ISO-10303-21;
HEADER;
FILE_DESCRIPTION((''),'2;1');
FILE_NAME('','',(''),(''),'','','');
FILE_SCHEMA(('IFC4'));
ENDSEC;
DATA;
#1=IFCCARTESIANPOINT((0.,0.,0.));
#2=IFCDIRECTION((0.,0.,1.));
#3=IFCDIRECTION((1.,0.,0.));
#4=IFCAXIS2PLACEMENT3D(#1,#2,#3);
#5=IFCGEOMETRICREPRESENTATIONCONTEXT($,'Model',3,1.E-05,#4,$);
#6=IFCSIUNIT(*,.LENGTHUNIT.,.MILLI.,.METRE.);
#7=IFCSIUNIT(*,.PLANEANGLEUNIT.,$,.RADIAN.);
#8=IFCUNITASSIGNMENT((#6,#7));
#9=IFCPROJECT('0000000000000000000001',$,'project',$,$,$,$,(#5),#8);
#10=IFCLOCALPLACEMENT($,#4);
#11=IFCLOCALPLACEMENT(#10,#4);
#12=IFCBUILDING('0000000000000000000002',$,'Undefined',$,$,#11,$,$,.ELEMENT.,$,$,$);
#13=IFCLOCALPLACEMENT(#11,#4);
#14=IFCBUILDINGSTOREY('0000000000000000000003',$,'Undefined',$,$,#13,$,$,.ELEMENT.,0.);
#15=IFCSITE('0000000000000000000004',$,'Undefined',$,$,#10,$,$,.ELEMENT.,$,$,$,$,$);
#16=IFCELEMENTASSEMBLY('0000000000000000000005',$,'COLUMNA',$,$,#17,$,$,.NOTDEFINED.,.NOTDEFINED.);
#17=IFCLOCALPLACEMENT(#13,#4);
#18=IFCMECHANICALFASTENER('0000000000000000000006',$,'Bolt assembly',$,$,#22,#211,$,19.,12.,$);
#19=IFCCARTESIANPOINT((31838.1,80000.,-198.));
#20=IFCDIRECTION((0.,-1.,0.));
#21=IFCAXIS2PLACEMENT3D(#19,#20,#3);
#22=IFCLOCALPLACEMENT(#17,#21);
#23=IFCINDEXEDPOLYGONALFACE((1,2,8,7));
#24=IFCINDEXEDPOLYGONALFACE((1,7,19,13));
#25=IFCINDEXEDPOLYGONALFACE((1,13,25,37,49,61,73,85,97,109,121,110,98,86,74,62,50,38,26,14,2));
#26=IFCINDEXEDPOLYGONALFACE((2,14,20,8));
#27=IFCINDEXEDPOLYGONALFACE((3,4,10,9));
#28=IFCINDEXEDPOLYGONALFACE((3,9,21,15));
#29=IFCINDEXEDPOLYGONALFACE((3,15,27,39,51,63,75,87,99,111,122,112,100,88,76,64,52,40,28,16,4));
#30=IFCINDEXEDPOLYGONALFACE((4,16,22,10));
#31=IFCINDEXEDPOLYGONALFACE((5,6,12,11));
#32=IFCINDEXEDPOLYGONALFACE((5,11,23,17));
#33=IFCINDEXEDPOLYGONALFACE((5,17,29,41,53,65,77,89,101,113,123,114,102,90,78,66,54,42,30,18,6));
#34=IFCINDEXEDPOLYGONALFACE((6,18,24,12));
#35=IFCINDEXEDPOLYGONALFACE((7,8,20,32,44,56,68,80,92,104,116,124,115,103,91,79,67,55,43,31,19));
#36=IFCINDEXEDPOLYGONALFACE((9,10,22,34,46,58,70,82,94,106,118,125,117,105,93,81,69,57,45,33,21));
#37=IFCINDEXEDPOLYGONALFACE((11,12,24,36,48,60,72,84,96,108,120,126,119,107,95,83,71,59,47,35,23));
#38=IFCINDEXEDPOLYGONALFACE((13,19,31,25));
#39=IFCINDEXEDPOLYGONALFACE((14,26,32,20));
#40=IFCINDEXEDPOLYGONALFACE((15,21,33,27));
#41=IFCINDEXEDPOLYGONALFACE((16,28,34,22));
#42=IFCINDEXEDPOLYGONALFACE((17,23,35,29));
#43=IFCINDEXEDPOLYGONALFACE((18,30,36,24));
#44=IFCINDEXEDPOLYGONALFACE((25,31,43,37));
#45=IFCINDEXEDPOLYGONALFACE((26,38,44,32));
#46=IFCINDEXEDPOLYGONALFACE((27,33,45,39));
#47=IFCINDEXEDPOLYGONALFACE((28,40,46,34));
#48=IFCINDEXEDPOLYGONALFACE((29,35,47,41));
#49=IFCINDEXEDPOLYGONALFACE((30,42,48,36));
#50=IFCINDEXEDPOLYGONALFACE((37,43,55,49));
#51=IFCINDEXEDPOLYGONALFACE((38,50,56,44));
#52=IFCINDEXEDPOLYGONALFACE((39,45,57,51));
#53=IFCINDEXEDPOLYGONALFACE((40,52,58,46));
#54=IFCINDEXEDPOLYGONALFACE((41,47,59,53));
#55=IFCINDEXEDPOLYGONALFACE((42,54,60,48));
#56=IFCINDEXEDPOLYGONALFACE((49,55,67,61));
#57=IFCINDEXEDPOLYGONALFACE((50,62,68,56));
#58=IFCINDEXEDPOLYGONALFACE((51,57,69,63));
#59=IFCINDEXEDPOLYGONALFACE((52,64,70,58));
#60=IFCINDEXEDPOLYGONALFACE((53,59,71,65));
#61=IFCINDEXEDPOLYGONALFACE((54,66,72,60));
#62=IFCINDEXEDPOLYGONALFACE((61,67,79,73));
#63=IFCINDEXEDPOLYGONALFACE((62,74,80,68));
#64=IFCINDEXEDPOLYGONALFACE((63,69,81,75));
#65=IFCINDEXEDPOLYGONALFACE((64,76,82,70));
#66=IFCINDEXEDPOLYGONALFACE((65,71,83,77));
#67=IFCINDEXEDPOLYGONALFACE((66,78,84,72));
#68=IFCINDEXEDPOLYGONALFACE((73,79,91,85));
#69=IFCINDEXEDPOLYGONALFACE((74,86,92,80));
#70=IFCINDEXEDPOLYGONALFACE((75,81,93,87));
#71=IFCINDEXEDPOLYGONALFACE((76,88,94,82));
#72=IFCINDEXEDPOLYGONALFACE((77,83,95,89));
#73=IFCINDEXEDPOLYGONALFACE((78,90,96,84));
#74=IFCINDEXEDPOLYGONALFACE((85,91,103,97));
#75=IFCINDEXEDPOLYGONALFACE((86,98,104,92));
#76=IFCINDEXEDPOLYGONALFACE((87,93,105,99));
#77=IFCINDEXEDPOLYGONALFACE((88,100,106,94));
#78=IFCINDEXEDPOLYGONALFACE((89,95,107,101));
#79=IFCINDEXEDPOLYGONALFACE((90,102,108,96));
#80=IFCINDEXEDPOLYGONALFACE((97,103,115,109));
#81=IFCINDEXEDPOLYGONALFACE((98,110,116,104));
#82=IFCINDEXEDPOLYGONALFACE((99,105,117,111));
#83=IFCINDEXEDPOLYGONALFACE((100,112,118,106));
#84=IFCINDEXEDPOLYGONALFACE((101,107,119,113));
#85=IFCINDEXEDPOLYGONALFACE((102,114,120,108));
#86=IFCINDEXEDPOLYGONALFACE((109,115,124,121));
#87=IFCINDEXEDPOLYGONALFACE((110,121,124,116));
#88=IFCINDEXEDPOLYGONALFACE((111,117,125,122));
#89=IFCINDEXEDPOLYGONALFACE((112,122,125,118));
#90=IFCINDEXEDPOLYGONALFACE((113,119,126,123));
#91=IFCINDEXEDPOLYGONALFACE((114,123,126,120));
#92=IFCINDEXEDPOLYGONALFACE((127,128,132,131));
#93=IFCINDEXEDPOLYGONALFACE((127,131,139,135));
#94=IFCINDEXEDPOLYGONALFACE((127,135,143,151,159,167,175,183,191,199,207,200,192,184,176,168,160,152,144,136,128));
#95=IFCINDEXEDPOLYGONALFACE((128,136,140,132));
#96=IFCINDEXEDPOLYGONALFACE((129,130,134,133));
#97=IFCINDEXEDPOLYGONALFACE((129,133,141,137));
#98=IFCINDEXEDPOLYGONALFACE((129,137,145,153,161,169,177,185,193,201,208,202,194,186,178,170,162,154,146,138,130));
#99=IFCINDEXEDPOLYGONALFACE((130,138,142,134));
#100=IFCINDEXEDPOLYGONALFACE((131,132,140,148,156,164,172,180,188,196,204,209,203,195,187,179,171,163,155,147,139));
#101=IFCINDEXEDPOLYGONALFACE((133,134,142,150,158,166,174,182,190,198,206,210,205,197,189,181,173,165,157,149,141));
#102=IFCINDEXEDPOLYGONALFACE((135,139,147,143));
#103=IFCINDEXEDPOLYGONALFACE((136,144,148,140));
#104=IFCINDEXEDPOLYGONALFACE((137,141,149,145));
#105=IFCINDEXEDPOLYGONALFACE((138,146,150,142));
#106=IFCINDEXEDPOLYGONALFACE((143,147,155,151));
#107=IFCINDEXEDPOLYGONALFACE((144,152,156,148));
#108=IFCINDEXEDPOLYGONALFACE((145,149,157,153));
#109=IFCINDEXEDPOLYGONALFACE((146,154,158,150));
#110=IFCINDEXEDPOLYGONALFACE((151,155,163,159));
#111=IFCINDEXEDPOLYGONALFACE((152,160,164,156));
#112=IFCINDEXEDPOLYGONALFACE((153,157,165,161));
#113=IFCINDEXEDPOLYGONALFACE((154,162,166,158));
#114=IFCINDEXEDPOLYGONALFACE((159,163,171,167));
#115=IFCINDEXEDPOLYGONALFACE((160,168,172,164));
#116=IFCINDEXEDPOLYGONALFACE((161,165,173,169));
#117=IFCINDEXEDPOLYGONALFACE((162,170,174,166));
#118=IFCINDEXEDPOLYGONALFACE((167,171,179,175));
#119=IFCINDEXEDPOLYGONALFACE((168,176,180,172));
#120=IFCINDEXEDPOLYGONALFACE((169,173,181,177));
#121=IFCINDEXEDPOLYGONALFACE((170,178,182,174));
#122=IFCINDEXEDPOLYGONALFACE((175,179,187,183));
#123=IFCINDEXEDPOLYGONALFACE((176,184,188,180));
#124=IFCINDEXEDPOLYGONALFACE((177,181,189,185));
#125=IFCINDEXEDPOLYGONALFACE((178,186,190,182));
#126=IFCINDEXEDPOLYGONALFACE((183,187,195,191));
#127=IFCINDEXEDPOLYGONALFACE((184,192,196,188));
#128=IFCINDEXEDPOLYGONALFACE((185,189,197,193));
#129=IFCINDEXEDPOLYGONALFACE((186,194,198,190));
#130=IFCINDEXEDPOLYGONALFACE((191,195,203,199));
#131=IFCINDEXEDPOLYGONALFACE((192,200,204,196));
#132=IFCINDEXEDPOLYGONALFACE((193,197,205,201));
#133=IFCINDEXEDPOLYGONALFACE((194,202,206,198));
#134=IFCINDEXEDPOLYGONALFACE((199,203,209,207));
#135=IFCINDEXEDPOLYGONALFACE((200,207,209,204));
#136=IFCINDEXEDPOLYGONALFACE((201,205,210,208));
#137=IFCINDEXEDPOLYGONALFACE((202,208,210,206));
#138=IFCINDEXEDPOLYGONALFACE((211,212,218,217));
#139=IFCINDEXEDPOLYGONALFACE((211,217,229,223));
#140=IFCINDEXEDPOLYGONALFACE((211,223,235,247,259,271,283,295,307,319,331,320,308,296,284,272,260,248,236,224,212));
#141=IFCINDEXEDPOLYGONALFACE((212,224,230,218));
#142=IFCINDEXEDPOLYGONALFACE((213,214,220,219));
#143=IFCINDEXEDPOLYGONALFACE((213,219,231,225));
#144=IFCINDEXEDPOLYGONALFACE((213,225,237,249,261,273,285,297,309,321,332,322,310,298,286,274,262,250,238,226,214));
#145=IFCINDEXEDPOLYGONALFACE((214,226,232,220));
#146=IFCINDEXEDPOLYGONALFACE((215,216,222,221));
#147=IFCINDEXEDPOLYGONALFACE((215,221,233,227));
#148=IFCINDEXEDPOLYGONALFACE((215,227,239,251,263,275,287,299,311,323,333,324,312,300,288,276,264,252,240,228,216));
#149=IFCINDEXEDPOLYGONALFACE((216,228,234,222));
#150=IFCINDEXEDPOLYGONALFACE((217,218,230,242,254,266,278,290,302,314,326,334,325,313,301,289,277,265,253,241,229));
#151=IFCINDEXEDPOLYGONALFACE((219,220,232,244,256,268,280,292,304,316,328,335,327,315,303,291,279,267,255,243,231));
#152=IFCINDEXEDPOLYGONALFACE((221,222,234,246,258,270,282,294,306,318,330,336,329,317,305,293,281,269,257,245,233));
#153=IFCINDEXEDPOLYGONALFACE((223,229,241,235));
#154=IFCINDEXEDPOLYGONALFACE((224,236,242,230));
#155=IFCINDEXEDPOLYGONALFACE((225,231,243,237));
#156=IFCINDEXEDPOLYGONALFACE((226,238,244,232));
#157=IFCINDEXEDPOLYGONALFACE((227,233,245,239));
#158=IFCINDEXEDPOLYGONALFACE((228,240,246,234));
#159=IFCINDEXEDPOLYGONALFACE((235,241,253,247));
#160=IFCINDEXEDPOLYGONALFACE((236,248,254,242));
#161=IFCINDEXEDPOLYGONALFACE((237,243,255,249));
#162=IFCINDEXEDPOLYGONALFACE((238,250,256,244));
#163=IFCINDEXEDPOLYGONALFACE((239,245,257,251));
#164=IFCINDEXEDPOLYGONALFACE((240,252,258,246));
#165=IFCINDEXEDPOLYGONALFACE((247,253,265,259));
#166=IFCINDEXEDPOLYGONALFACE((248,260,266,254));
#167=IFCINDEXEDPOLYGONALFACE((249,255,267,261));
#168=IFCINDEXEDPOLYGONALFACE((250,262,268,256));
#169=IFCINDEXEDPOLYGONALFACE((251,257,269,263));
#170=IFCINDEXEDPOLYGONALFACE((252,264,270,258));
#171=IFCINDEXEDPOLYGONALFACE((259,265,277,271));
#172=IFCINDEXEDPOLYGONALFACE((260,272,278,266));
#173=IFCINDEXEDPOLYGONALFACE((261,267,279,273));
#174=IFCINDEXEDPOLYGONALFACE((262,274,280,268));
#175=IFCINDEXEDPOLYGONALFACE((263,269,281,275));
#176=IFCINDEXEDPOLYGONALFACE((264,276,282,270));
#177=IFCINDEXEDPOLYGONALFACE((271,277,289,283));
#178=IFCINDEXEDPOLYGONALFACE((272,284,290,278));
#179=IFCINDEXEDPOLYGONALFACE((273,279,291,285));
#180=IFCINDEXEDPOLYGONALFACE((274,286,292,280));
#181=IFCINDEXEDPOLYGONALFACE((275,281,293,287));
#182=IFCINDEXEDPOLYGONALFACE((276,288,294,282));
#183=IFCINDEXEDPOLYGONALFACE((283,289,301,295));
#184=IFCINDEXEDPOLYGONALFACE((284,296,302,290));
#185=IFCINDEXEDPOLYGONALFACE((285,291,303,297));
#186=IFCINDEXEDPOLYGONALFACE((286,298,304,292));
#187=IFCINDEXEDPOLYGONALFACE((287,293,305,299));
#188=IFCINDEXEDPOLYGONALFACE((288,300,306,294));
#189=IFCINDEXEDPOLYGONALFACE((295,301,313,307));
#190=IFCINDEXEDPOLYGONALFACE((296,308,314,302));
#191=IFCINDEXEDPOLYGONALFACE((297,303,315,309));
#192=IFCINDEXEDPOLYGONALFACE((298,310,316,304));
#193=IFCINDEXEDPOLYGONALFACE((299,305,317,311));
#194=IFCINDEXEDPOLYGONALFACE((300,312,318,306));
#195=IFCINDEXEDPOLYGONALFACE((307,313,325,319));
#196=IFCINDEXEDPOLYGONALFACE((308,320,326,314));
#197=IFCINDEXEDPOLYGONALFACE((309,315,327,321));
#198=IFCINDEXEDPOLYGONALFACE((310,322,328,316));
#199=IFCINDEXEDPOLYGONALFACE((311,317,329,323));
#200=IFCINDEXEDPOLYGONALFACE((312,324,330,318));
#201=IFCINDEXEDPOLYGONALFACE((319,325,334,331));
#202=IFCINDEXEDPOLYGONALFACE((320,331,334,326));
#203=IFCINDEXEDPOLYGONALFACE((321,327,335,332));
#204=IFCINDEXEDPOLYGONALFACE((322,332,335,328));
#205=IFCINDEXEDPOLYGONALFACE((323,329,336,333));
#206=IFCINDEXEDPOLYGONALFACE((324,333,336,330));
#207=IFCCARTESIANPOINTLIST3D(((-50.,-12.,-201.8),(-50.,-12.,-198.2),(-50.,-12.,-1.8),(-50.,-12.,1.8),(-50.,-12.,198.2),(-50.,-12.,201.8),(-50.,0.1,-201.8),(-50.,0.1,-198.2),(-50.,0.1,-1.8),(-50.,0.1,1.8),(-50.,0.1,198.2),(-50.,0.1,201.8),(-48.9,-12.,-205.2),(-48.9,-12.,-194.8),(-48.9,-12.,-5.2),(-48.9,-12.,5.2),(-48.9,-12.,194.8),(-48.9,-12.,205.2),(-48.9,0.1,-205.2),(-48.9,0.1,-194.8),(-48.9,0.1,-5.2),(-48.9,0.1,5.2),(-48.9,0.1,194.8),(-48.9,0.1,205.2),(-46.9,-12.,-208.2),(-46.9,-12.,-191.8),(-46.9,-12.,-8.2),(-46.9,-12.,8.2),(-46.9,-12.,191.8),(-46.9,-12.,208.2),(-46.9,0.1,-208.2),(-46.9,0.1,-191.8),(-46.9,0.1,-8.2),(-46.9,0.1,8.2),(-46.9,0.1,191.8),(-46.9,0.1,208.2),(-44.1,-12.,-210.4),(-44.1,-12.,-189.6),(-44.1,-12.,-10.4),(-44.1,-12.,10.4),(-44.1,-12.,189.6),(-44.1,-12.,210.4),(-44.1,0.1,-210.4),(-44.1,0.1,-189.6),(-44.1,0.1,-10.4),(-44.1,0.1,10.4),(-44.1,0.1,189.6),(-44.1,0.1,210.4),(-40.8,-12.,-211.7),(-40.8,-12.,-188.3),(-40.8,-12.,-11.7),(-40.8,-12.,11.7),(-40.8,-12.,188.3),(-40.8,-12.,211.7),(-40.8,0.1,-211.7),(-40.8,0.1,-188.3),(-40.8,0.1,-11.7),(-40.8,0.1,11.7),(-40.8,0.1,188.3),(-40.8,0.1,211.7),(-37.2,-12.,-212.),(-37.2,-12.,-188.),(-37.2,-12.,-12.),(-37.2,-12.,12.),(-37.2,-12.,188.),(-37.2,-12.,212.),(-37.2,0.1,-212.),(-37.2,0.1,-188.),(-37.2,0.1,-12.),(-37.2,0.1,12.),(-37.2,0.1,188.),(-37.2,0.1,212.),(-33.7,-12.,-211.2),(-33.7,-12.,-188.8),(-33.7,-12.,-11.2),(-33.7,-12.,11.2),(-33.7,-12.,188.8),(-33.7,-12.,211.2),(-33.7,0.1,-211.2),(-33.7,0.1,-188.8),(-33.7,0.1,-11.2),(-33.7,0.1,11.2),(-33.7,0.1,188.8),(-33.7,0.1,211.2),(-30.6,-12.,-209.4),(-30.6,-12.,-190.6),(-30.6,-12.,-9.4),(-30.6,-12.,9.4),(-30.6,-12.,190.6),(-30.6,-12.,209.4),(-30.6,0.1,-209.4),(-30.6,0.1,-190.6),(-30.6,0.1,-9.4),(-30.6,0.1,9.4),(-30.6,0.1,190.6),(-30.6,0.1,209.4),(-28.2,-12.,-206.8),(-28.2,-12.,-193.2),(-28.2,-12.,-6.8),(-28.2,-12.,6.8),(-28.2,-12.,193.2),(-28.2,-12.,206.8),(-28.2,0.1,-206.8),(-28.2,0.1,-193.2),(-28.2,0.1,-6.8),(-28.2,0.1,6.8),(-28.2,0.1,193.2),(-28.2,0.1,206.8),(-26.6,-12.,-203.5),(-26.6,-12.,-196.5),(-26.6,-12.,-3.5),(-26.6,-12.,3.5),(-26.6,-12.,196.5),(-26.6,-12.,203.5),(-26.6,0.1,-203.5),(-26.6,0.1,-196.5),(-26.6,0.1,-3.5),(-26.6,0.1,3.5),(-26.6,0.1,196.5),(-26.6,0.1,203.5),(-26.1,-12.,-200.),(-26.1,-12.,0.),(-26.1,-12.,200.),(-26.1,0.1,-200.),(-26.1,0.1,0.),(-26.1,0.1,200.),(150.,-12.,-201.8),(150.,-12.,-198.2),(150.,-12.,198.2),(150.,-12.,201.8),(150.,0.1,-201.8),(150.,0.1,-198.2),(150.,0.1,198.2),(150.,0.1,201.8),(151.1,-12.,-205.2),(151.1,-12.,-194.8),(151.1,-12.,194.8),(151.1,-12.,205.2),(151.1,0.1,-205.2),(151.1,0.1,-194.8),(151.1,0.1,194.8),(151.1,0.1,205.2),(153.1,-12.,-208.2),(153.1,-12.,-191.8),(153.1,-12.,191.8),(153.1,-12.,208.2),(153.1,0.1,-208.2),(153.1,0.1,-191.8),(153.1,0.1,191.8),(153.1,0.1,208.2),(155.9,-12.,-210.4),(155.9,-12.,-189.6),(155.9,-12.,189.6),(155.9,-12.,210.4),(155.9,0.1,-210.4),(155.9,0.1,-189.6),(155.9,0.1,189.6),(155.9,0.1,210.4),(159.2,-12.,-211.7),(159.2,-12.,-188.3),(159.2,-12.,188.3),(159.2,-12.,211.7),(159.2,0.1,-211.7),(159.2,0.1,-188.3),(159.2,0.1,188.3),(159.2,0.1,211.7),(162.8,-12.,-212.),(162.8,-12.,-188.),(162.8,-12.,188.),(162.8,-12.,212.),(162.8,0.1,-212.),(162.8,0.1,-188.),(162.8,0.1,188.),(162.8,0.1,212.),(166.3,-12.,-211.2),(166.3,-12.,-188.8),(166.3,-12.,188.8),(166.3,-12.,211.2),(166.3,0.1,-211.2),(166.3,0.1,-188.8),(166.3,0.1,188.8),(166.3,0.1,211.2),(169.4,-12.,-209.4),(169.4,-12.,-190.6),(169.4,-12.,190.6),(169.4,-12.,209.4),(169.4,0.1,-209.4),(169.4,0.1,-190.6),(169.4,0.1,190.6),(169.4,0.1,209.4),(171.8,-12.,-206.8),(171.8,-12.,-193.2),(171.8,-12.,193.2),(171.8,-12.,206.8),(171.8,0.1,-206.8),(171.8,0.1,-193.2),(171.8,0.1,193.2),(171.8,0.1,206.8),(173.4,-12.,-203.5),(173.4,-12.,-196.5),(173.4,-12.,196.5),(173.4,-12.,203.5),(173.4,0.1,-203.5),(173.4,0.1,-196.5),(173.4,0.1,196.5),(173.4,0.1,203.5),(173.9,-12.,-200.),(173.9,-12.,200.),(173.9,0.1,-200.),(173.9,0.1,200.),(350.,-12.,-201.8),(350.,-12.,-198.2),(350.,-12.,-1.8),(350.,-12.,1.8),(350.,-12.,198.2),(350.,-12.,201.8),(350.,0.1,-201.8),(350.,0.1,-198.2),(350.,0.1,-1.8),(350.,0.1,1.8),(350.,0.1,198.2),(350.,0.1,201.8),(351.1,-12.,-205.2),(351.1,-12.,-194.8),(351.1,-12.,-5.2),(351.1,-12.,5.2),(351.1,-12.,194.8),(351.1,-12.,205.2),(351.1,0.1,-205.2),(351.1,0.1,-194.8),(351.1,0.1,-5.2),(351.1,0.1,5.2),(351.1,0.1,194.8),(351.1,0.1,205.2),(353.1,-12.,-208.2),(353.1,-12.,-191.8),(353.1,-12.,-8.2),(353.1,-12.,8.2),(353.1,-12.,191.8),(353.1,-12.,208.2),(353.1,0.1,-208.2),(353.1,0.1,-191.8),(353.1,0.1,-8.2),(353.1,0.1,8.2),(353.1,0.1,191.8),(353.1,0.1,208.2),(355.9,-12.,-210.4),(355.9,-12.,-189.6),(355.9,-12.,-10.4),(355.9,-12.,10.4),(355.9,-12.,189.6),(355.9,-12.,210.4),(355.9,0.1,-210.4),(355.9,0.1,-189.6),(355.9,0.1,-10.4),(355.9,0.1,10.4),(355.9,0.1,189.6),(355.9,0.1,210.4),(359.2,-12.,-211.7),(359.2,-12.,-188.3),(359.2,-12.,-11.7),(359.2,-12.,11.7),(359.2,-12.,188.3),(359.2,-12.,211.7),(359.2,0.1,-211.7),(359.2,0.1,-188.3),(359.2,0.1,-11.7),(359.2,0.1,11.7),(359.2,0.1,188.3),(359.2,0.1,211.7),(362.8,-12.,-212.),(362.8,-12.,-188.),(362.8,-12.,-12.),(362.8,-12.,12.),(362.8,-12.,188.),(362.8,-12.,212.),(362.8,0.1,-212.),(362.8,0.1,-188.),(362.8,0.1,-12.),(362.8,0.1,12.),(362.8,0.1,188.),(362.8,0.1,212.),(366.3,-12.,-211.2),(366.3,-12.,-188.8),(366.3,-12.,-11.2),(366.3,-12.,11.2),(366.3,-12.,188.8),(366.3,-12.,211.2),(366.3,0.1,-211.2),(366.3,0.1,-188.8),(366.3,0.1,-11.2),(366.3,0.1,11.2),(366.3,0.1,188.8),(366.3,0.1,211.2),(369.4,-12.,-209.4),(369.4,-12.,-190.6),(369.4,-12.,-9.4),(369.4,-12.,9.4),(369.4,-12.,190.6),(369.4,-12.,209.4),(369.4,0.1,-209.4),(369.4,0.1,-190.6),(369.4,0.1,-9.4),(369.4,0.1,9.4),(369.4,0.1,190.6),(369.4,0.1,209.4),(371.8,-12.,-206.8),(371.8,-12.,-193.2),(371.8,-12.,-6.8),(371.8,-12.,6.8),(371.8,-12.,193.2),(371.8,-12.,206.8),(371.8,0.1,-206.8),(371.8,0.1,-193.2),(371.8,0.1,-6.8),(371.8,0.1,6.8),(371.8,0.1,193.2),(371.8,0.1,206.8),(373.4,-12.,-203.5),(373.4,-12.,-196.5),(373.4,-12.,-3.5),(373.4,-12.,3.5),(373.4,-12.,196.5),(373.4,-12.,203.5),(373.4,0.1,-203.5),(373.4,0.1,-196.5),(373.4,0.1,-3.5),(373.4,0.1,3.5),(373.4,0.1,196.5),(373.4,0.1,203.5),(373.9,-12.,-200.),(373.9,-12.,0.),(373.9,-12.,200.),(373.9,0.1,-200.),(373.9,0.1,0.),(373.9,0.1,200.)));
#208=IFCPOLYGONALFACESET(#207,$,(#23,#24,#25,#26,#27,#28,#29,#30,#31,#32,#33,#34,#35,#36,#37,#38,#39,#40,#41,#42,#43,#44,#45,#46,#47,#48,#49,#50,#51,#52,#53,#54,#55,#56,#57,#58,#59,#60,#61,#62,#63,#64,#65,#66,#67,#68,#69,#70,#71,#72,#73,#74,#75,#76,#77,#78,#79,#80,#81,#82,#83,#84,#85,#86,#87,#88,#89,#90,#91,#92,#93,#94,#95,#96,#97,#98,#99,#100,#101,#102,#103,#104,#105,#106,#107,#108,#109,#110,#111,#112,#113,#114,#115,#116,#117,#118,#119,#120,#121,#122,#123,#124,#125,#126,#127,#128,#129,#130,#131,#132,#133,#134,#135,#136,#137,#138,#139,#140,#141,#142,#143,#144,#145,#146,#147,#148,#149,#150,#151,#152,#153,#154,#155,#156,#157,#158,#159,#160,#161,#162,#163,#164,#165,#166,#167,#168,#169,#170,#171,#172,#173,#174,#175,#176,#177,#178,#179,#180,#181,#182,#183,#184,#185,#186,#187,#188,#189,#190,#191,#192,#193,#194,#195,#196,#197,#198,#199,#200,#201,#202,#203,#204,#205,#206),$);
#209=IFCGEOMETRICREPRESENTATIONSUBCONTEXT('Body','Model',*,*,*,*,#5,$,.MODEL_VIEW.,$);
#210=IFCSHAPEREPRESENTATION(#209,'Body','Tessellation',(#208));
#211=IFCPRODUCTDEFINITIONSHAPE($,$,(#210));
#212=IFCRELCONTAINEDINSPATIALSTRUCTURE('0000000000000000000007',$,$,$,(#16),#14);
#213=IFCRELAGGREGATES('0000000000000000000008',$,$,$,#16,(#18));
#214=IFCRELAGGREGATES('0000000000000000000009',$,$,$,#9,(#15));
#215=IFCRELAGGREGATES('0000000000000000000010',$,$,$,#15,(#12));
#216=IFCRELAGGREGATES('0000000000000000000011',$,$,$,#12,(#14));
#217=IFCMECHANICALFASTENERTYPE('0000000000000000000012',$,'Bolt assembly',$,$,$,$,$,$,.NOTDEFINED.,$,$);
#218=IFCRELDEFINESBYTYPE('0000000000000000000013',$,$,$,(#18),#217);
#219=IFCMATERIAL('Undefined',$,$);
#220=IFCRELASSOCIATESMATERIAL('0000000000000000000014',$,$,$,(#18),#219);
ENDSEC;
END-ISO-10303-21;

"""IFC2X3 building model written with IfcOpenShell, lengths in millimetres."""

from ifc_helpers import new_model, si_unit, frame, origin_with_axes, origin_2d_with_axis, place, context, subcontext, project, spatial, circle, extrude, source, transform, mapped, material, type_object, element, aggregate, save


model = new_model("IFC2X3")

# Units and contexts
model_context = context("Model", 3, precision=1e-05, world=origin_with_axes())
body_context = subcontext(model_context, "Body", "Model", "MODEL_VIEW")
ifc_project = project(units=[si_unit("LENGTHUNIT", "METRE", prefix="MILLI"), si_unit("PLANEANGLEUNIT", "RADIAN")], contexts=[model_context])

# Site, building, storey
site_placement = place(None, origin_with_axes())
site = spatial("IfcSite", under=ifc_project, at=site_placement, Name="Undefined", CompositionType="ELEMENT")
building_placement = place(site_placement, origin_with_axes())
building = spatial("IfcBuilding", under=site, at=building_placement, Name="Undefined", CompositionType="ELEMENT")
storey_placement = place(building_placement, origin_with_axes())
storey = spatial("IfcBuildingStorey", under=building, at=storey_placement, Name="Undefined", CompositionType="ELEMENT", Elevation=0.0)

# Element assembly
assembly_1_placement = place(storey_placement, origin_with_axes())
assembly_1 = element("IfcElementAssembly", 1, at=assembly_1_placement, inside=storey, Name="COLUMNA", AssemblyPlace="NOTDEFINED", PredefinedType="NOTDEFINED")

# Mechanical fastener
ifc_material_1 = material(Name="Undefined")
mechanical_fastener_type = type_object("IfcMechanicalFastenerType", Name="Bolt assembly")
shared_shape = source(origin_with_axes(), body_context, "Body", "SweptSolid", [
    extrude(circle(Radius=12.0, at=origin_2d_with_axis()), frame((0.0, -12.0, 0.0), z_axis=(0.0, 1.0, 0.0), x_axis=(1.0, 0.0, 0.0)), (0.0, 0.0, 1.0), 12.1),
])
mechanical_fastener_placement = place(assembly_1_placement, frame((31838.1, 80000.0, -198.0), z_axis=(0.0, -1.0, 0.0), x_axis=(1.0, 0.0, 0.0)))
mechanical_fastener = element("IfcMechanicalFastener", 2, at=mechanical_fastener_placement, type_object=mechanical_fastener_type, material=ifc_material_1, Name="Bolt assembly", NominalDiameter=19.0, NominalLength=12.0, context=body_context, shape_type="MappedRepresentation", body=[
    mapped(shared_shape, transform((-38.1, 0.0, -200.0))),
    mapped(shared_shape, transform((-38.1, 0.0, 0.0))),
    mapped(shared_shape, transform((-38.1, 0.0, 200.0))),
    mapped(shared_shape, transform((161.9, 0.0, -200.0))),
    mapped(shared_shape, transform((161.9, 0.0, 200.0))),
    mapped(shared_shape, transform((361.9, 0.0, -200.0))),
    mapped(shared_shape, transform((361.9, 0.0, 0.0))),
    mapped(shared_shape, transform((361.9, 0.0, 200.0))),
])
aggregate(assembly_1, [mechanical_fastener])

save(model, "model.ifc")
